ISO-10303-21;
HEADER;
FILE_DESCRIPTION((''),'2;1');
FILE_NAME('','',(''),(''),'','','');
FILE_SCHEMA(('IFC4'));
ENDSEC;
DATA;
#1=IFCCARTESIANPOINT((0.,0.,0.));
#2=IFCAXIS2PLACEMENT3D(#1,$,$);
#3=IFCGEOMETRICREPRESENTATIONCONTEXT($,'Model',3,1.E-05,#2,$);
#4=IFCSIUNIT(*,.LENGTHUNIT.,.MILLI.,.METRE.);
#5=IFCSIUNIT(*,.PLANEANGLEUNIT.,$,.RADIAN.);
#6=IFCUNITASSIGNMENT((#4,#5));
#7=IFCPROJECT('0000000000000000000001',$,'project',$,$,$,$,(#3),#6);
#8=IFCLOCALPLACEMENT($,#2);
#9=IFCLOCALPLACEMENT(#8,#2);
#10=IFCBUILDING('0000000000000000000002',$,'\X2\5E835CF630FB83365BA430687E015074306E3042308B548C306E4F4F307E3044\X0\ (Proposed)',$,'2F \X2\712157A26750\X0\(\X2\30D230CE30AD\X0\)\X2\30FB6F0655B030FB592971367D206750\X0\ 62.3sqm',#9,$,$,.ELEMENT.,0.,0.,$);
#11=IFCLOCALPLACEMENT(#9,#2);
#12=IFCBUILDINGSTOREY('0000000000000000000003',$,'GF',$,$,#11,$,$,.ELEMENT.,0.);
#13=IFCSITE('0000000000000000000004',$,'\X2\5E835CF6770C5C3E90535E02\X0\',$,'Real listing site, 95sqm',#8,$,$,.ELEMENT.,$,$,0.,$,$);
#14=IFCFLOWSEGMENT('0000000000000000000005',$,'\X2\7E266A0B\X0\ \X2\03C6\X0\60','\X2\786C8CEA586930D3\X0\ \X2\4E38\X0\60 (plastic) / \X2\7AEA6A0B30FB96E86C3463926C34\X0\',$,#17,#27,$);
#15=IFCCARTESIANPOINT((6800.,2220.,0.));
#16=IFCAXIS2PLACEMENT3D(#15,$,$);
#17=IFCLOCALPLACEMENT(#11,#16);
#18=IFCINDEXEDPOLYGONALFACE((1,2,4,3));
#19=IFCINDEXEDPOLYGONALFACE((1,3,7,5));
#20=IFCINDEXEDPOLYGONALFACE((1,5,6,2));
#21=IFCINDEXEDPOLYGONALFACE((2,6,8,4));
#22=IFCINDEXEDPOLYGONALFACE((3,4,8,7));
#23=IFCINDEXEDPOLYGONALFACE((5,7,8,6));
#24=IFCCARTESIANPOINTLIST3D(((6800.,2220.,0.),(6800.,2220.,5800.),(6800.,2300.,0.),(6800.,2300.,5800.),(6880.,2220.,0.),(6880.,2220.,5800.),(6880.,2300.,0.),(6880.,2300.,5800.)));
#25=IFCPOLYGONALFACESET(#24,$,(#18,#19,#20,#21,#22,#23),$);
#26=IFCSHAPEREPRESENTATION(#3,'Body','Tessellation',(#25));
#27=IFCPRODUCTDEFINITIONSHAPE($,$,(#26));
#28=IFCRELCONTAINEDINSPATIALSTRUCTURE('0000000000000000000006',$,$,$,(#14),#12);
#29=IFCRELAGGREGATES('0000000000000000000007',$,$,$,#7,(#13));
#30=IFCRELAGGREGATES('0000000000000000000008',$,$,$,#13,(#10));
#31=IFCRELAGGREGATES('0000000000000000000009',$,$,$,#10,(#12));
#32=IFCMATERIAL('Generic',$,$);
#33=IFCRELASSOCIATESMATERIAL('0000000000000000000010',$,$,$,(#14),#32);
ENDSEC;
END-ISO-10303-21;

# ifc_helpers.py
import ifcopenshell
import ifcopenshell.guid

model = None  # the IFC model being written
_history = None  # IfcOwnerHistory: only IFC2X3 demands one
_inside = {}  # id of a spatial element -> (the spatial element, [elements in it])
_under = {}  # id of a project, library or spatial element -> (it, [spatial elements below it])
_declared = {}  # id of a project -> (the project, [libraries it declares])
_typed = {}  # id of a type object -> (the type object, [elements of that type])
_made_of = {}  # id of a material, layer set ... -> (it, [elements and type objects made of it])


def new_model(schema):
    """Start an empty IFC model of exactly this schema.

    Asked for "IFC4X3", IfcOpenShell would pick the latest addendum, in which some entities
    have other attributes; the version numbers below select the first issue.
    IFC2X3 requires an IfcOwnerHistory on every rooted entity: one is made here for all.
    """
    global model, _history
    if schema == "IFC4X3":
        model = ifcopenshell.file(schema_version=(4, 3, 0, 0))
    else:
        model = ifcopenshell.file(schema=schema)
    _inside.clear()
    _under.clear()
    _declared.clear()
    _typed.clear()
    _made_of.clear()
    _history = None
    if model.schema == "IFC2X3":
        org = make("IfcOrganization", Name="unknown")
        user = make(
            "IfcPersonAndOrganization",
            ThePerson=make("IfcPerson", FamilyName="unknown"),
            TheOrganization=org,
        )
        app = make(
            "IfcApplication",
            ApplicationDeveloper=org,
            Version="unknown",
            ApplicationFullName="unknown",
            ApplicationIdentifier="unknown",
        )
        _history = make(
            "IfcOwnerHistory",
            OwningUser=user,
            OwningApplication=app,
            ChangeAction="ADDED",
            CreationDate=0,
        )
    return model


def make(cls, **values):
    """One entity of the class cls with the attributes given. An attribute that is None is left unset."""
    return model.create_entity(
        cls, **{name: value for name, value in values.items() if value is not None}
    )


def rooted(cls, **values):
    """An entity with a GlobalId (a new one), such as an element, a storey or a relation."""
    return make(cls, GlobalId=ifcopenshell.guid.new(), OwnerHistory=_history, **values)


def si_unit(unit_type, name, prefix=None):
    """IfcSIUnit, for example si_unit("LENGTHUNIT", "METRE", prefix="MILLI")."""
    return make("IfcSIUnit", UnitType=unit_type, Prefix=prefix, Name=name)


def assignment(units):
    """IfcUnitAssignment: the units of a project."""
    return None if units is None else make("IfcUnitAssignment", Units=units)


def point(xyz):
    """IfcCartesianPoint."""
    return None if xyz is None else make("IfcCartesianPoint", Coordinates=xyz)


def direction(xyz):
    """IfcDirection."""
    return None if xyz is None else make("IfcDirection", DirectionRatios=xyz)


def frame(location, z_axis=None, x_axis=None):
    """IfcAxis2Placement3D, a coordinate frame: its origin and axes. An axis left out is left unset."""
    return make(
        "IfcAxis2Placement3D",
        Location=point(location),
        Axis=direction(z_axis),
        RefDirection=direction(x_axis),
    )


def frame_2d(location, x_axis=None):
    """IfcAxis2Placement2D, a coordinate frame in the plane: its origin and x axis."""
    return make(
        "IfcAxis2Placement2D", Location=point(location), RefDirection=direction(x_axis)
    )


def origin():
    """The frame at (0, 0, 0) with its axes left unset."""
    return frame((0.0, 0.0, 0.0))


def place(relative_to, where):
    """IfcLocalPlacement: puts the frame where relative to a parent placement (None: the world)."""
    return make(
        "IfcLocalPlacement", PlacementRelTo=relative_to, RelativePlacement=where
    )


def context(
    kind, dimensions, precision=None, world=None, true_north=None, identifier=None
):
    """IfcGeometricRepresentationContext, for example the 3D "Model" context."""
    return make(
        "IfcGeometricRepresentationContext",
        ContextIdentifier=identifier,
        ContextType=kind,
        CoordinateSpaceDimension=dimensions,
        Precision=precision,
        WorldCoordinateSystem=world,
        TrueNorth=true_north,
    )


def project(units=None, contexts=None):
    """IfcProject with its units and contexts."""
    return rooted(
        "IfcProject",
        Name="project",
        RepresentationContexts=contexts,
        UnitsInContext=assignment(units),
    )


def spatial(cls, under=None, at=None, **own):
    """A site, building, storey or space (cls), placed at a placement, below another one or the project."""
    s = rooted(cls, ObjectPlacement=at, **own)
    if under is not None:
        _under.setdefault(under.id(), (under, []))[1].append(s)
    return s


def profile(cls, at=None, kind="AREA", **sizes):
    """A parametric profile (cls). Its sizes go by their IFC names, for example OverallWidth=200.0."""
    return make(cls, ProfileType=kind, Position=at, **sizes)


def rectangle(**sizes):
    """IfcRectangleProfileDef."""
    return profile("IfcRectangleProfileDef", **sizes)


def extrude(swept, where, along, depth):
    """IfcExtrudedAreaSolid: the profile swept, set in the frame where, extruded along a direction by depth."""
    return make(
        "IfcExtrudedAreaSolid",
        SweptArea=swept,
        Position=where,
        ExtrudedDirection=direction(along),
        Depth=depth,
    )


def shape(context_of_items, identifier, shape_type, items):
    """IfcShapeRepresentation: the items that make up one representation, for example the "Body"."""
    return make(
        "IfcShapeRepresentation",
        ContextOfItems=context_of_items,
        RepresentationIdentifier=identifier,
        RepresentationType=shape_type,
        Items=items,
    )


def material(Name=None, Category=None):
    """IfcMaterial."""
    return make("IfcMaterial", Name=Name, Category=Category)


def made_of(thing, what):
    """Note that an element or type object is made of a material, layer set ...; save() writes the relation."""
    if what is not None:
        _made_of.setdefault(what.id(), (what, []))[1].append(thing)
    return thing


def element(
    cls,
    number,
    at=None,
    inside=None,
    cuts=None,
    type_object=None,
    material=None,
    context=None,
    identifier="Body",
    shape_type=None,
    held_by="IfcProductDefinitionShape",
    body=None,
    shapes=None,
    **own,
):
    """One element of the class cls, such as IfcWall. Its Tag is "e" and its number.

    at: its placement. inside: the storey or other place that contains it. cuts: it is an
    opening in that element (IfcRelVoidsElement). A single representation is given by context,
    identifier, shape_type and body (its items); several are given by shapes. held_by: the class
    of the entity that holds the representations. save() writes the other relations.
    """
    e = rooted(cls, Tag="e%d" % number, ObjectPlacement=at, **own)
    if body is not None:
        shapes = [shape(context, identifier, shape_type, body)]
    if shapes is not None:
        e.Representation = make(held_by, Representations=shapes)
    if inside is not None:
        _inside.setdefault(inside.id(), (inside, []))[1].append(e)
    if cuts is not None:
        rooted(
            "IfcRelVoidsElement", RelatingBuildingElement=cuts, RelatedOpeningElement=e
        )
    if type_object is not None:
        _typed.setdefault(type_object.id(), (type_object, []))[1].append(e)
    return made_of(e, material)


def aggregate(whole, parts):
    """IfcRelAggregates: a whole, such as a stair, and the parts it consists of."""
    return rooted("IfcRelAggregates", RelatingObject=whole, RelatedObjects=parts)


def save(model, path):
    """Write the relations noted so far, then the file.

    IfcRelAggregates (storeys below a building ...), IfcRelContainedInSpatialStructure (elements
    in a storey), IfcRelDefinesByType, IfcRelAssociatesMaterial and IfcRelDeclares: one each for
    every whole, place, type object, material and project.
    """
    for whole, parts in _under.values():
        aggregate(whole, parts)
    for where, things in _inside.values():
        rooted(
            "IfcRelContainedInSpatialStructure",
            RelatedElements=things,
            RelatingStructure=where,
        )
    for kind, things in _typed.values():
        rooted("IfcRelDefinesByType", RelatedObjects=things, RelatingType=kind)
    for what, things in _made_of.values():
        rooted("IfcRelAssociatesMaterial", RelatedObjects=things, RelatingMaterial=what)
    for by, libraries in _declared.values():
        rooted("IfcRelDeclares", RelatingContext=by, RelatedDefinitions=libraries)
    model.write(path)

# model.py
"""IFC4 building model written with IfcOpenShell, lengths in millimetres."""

from ifc_helpers import new_model, si_unit, frame, frame_2d, origin, place, context, project, spatial, rectangle, extrude, material, element, save


model = new_model("IFC4")

# Units and contexts
model_context = context("Model", 3, precision=1e-05, world=origin())
ifc_project = project(units=[si_unit("LENGTHUNIT", "METRE", prefix="MILLI"), si_unit("PLANEANGLEUNIT", "RADIAN")], contexts=[model_context])

# Site, building, storey
site_placement = place(None, origin())
site = spatial("IfcSite", under=ifc_project, at=site_placement, Name="広島県尾道市", ObjectType="Real listing site, 95sqm", CompositionType="ELEMENT", RefElevation=0.0)
building_placement = place(site_placement, origin())
building = spatial("IfcBuilding", under=site, at=building_placement, Name="広島・茶室と縁側のある和の住まい (Proposed)", ObjectType="2F 無垢材(ヒノキ)・漆喰・天然素材 62.3sqm", CompositionType="ELEMENT", ElevationOfRefHeight=0.0, ElevationOfTerrain=0.0)
storey_placement = place(building_placement, origin())
storey = spatial("IfcBuildingStorey", under=building, at=storey_placement, Name="GF", CompositionType="ELEMENT", Elevation=0.0)

# Shared definitions
ifc_material_1 = material(Name="Generic")

# Flow segment
flow_segment_placement = place(storey_placement, frame((6800.0, 2220.0, 0.0)))
element("IfcFlowSegment", 1, at=flow_segment_placement, inside=storey, material=ifc_material_1, Name="縦樋 φ60", Description="硬質塩ビ 丸60 (plastic) / 竪樋・雨水排水", context=model_context, shape_type="SweptSolid", body=[
    extrude(rectangle(XDim=80.0, YDim=80.0, at=frame_2d((40.0, 40.0))), frame((6800.0, 2220.0, 0.0)), (0.0, 0.0, 1.0), 5800.0),
])

save(model, "model.ifc")
